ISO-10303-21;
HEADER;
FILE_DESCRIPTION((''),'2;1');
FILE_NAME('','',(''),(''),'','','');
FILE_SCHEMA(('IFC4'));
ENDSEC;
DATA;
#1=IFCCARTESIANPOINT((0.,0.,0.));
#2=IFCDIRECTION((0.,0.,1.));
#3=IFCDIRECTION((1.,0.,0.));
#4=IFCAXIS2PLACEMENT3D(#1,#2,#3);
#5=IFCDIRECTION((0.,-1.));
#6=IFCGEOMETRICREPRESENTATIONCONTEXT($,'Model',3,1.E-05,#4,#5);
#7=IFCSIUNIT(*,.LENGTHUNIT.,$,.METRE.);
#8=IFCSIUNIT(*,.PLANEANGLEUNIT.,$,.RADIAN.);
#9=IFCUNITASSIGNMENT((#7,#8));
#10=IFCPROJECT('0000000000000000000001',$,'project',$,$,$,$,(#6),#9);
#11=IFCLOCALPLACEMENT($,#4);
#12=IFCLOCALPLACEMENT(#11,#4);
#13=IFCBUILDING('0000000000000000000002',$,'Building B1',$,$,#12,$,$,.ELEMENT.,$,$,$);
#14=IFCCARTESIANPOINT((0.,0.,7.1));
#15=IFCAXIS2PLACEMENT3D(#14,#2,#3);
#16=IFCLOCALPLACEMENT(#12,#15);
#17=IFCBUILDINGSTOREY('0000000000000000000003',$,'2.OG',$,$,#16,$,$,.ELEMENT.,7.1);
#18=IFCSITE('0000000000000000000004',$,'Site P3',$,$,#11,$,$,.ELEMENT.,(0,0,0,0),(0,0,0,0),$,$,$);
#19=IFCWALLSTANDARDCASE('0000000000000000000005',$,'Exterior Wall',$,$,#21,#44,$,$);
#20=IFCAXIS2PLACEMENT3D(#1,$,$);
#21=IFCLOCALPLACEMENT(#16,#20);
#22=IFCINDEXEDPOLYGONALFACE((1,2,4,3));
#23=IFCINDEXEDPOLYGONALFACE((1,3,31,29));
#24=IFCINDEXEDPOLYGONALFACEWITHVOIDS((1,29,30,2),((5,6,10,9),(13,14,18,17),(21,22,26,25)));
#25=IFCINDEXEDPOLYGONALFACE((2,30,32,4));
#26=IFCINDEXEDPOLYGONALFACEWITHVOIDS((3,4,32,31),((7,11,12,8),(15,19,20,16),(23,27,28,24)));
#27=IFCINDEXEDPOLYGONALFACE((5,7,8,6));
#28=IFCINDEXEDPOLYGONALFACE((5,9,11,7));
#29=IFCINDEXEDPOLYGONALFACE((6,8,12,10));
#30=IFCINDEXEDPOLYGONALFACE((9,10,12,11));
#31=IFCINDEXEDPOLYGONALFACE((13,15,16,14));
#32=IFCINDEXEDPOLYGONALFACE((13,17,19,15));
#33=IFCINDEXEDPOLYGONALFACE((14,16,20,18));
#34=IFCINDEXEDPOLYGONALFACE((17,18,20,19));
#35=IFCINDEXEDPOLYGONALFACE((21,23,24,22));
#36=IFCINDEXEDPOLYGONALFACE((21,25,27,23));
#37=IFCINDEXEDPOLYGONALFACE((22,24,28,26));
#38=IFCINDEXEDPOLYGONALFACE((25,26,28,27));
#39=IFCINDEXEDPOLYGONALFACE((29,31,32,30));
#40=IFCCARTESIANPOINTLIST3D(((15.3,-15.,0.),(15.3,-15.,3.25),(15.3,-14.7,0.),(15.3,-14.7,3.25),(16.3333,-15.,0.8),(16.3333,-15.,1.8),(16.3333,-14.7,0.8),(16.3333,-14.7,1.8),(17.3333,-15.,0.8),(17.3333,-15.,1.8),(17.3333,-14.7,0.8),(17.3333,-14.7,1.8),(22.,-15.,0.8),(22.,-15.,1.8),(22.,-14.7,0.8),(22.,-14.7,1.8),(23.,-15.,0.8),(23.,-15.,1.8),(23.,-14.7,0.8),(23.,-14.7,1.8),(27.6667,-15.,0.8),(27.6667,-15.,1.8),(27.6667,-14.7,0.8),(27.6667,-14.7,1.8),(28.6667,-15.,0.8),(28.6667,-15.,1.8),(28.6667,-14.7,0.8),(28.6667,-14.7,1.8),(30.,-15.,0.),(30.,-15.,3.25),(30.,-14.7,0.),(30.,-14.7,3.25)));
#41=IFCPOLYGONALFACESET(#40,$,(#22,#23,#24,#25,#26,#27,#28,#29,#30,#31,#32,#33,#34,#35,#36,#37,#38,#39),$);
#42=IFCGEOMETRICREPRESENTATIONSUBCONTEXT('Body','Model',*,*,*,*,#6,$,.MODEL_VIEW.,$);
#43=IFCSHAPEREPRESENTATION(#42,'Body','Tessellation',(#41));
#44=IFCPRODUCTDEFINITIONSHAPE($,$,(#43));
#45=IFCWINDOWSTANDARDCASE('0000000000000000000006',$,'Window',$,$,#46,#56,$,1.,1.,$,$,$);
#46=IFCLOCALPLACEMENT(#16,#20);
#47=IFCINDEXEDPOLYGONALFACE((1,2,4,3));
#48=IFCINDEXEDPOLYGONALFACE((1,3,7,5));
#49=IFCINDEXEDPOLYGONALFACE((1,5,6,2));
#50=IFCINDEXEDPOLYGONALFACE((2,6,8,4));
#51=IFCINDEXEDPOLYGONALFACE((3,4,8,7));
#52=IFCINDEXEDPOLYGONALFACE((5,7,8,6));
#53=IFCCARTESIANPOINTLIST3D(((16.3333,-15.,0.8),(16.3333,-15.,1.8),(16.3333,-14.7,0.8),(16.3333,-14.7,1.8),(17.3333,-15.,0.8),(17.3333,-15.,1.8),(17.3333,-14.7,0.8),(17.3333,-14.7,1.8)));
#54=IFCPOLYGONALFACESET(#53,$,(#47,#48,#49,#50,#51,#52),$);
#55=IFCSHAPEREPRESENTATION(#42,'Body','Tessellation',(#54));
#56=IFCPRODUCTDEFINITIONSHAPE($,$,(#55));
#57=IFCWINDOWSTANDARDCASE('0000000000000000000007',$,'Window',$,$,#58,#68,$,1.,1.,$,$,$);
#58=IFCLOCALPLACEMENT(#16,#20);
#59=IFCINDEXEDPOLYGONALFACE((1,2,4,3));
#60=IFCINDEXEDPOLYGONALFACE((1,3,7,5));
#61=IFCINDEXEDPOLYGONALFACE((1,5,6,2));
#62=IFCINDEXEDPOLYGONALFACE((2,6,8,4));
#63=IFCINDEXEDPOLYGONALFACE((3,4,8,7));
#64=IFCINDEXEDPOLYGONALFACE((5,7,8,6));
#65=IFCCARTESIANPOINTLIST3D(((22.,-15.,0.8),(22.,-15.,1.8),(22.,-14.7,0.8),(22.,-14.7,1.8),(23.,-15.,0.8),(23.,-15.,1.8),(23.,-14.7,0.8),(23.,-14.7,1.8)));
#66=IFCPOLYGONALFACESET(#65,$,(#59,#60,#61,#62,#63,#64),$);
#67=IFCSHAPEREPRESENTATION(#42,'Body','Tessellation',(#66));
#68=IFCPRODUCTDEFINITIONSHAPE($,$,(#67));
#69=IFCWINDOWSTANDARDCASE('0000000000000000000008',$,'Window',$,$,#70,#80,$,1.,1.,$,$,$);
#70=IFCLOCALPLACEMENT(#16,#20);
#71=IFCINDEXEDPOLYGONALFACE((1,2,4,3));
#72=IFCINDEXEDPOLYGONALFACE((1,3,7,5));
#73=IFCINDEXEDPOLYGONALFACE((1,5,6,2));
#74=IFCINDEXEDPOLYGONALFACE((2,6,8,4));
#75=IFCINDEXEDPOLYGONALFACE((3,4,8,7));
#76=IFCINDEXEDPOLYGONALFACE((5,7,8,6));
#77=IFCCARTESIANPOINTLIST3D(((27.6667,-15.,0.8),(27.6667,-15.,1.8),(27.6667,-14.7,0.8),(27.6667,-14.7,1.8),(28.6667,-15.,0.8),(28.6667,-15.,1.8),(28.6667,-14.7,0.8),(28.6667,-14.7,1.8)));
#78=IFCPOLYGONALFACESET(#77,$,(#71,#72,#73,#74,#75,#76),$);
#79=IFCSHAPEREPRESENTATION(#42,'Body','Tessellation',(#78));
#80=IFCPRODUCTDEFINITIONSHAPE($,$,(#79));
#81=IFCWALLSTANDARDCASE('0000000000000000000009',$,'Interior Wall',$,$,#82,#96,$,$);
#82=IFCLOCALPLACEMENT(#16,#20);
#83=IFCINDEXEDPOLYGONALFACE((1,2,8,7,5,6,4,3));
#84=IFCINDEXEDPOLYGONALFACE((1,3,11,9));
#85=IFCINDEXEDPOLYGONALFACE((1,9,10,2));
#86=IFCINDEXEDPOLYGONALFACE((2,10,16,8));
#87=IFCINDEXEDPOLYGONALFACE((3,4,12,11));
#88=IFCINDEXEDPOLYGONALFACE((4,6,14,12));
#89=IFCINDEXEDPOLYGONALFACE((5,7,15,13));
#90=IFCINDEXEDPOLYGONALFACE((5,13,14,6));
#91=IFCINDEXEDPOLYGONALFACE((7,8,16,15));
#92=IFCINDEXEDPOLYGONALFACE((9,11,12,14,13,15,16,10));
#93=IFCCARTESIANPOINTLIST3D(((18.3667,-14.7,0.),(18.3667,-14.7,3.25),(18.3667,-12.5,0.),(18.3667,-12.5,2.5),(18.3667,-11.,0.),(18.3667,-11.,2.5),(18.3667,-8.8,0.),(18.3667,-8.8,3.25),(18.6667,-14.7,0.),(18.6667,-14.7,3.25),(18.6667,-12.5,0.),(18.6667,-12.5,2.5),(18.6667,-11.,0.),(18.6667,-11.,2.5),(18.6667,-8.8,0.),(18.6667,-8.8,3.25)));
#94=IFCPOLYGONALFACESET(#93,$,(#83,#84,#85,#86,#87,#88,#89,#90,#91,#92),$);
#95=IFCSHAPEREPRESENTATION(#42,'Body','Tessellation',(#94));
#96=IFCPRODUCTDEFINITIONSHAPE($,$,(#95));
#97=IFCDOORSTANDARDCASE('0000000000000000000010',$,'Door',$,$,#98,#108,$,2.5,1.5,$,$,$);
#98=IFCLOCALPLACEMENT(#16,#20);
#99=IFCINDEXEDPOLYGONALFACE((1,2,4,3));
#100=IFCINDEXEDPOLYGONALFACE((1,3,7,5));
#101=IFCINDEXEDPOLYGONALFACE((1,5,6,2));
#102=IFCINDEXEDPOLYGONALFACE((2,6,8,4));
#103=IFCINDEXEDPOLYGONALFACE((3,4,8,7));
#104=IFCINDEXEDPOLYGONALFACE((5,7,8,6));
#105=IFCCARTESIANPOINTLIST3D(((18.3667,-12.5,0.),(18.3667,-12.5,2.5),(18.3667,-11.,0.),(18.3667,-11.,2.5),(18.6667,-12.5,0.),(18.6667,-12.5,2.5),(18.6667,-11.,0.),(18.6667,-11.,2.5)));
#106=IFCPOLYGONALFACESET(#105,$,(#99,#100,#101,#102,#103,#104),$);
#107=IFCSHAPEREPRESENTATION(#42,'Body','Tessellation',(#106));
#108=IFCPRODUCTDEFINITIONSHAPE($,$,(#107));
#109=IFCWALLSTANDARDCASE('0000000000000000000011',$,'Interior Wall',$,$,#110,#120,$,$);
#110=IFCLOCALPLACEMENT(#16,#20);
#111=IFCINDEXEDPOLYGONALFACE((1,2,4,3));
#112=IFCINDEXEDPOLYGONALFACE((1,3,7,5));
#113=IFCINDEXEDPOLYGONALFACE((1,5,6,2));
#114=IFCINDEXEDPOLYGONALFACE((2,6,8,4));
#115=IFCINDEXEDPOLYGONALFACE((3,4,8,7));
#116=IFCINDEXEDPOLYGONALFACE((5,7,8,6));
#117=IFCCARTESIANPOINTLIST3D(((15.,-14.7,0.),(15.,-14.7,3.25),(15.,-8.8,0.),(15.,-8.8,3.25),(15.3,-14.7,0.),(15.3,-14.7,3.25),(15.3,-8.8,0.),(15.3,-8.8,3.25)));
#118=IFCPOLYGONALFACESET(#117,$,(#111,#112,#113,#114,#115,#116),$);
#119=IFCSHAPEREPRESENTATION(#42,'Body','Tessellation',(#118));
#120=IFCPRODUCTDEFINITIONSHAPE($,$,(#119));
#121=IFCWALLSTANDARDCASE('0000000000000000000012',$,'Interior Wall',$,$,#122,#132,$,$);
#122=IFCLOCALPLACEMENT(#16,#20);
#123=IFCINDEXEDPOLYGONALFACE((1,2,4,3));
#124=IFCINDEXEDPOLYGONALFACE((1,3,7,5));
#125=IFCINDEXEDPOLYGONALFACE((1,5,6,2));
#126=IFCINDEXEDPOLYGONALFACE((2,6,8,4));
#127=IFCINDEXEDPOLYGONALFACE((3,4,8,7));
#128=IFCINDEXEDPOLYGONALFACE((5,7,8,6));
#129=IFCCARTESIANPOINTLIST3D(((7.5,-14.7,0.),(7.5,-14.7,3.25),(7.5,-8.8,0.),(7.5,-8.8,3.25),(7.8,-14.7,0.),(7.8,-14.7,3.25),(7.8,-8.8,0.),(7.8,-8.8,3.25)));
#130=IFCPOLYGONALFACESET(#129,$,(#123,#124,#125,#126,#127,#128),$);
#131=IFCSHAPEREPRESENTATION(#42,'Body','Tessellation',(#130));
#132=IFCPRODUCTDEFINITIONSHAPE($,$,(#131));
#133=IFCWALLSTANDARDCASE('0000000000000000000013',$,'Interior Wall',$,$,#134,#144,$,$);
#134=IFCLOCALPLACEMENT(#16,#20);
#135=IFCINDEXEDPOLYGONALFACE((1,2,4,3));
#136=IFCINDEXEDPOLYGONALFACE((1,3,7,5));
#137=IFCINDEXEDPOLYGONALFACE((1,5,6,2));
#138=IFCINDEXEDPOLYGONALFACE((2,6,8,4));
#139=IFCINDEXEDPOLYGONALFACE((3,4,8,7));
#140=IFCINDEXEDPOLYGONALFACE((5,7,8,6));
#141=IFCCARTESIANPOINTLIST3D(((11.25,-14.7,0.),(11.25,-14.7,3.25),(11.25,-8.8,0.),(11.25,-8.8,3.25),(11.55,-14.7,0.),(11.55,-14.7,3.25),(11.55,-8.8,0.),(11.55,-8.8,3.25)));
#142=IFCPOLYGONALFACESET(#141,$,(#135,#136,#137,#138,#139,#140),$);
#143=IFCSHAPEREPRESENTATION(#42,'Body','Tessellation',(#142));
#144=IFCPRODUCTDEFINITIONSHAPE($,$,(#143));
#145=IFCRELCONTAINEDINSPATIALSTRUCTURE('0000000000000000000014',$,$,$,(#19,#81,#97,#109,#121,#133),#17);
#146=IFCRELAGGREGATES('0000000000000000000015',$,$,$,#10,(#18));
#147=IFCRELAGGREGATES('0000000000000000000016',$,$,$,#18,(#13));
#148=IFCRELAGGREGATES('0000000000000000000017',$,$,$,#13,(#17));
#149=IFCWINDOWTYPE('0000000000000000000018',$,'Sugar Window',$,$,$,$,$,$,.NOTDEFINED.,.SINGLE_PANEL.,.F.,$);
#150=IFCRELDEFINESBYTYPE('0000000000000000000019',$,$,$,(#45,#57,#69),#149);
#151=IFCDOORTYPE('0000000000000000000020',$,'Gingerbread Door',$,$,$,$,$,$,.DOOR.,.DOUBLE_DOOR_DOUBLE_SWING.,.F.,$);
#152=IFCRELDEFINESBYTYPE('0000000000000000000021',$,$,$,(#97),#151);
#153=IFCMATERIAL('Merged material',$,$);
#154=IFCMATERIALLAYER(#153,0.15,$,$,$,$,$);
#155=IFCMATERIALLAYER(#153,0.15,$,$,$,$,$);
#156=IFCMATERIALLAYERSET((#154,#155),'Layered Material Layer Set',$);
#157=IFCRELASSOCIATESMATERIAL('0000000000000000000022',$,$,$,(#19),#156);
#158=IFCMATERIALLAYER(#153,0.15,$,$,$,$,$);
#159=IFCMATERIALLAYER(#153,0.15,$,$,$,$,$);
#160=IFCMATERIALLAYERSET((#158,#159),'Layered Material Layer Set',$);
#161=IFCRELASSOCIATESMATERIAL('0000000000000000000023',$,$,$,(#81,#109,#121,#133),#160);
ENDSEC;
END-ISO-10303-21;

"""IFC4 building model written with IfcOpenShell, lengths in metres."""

from ifc_helpers import new_model, si_unit, direction, frame, origin_with_axes, place, context, subcontext, project, spatial, polyline, outline, extrude, source, transform, mapped, material, layer, layer_set, layer_usage, type_object, element, fill, save


model = new_model("IFC4")

# Units and contexts
model_context = context("Model", 3, precision=1e-05, world=origin_with_axes(), true_north=direction((0.0, -1.0)))
body_context = subcontext(model_context, "Body", "Model", "MODEL_VIEW")
ifc_project = project(units=[si_unit("LENGTHUNIT", "METRE"), si_unit("PLANEANGLEUNIT", "RADIAN")], contexts=[model_context])

# Site, building, storey
site_placement = place(None, origin_with_axes())
site = spatial("IfcSite", under=ifc_project, at=site_placement, Name="Site P3", CompositionType="ELEMENT", RefLatitude=(0, 0, 0, 0), RefLongitude=(0, 0, 0, 0))
building_placement = place(site_placement, origin_with_axes())
building = spatial("IfcBuilding", under=site, at=building_placement, Name="Building B1", CompositionType="ELEMENT")
storey_placement = place(building_placement, frame((0.0, 0.0, 7.1), z_axis=(0.0, 0.0, 1.0), x_axis=(1.0, 0.0, 0.0)))
storey = spatial("IfcBuildingStorey", under=building, at=storey_placement, Name="2.OG", CompositionType="ELEMENT", Elevation=7.1)

# Wall, openings, windows
ifc_material = material(Name="Merged material")
ifc_layer_1 = layer(ifc_material, 0.15)
ifc_layer_2 = layer(ifc_material, 0.15)
ifc_layer_set_1 = layer_set([ifc_layer_1, ifc_layer_2], Name="Layered Material Layer Set")
ifc_layer_usage_1 = layer_usage(ifc_layer_set_1, "AXIS2", "POSITIVE", -0.15)
wall_1_placement = place(storey_placement, frame((15.3, -14.85, 0.0), z_axis=(0.0, 0.0, 1.0), x_axis=(1.0, 0.0, 0.0)))
wall_1 = element("IfcWallStandardCase", 1, at=wall_1_placement, inside=storey, material=ifc_layer_usage_1, Name="Exterior Wall", context=body_context, shape_type="SweptSolid", body=[
    extrude(outline(polyline([(0.0, 0.15), (14.7, 0.15), (14.7, -0.15), (0.0, -0.15), (0.0, 0.15)])), origin_with_axes(), (0.0, 0.0, 1.0), 3.25),
])
opening_1_placement = place(wall_1_placement, frame((1.0333, 0.0, 0.8), z_axis=(0.0, 0.0, 1.0), x_axis=(1.0, 0.0, 0.0)))
opening_1 = element("IfcOpeningStandardCase", 2, at=opening_1_placement, cuts=wall_1, context=body_context, shape_type="SweptSolid", body=[
    extrude(outline(polyline([(0.0, 0.0), (0.0, 1.0), (1.0, 1.0), (1.0, 0.0), (0.0, 0.0)])), frame((0.0, -0.15, 0.0), z_axis=(0.0, 1.0, 0.0), x_axis=(0.0, 0.0, 1.0)), (0.0, 0.0, 1.0), 0.3),
])
opening_2_placement = place(wall_1_placement, frame((6.7, 0.0, 0.8), z_axis=(0.0, 0.0, 1.0), x_axis=(1.0, 0.0, 0.0)))
opening_2 = element("IfcOpeningStandardCase", 3, at=opening_2_placement, cuts=wall_1, context=body_context, shape_type="SweptSolid", body=[
    extrude(outline(polyline([(0.0, 0.0), (0.0, 1.0), (1.0, 1.0), (1.0, 0.0), (0.0, 0.0)])), frame((0.0, -0.15, 0.0), z_axis=(0.0, 1.0, 0.0), x_axis=(0.0, 0.0, 1.0)), (0.0, 0.0, 1.0), 0.3),
])
opening_3_placement = place(wall_1_placement, frame((12.3667, 0.0, 0.8), z_axis=(0.0, 0.0, 1.0), x_axis=(1.0, 0.0, 0.0)))
opening_3 = element("IfcOpeningStandardCase", 4, at=opening_3_placement, cuts=wall_1, context=body_context, shape_type="SweptSolid", body=[
    extrude(outline(polyline([(0.0, 0.0), (0.0, 1.0), (1.0, 1.0), (1.0, 0.0), (0.0, 0.0)])), frame((0.0, -0.15, 0.0), z_axis=(0.0, 1.0, 0.0), x_axis=(0.0, 0.0, 1.0)), (0.0, 0.0, 1.0), 0.3),
])
window_type = type_object("IfcWindowType", Name="Sugar Window", ParameterTakesPrecedence=False, PartitioningType="SINGLE_PANEL", PredefinedType="NOTDEFINED")
shared_shape_1 = source(origin_with_axes(), body_context, "Body", "SweptSolid", [
    extrude(outline(polyline([(0.0, 0.0), (0.0, 1.0), (1.0, 1.0), (1.0, 0.0), (0.0, 0.0)])), frame((0.0, -0.15, 0.0), z_axis=(0.0, 1.0, 0.0), x_axis=(0.0, 0.0, 1.0)), (0.0, 0.0, 1.0), 0.3),
])
window_1_placement = place(opening_1_placement, origin_with_axes())
window_1 = element("IfcWindowStandardCase", 5, at=window_1_placement, type_object=window_type, Name="Window", OverallHeight=1.0, OverallWidth=1.0, context=body_context, shape_type="MappedRepresentation", body=[
    mapped(shared_shape_1, transform((0.0, 0.0, 0.0))),
])
fill(opening_1, window_1)
window_2_placement = place(opening_2_placement, origin_with_axes())
window_2 = element("IfcWindowStandardCase", 6, at=window_2_placement, type_object=window_type, Name="Window", OverallHeight=1.0, OverallWidth=1.0, context=body_context, shape_type="MappedRepresentation", body=[
    mapped(shared_shape_1, transform((0.0, 0.0, 0.0))),
])
fill(opening_2, window_2)
window_3_placement = place(opening_3_placement, origin_with_axes())
window_3 = element("IfcWindowStandardCase", 7, at=window_3_placement, type_object=window_type, Name="Window", OverallHeight=1.0, OverallWidth=1.0, context=body_context, shape_type="MappedRepresentation", body=[
    mapped(shared_shape_1, transform((0.0, 0.0, 0.0))),
])
fill(opening_3, window_3)

# Wall, opening, door
ifc_layer_3 = layer(ifc_material, 0.15)
ifc_layer_4 = layer(ifc_material, 0.15)
ifc_layer_set_2 = layer_set([ifc_layer_3, ifc_layer_4], Name="Layered Material Layer Set")
ifc_layer_usage_2 = layer_usage(ifc_layer_set_2, "AXIS2", "POSITIVE", -0.15)
wall_2_placement = place(storey_placement, frame((18.5167, -8.8, 0.0), z_axis=(0.0, 0.0, 1.0), x_axis=(0.0, -1.0, 0.0)))
wall_2 = element("IfcWallStandardCase", 8, at=wall_2_placement, inside=storey, material=ifc_layer_usage_2, Name="Interior Wall", context=body_context, shape_type="SweptSolid", body=[
    extrude(outline(polyline([(0.0, 0.15), (5.9, 0.15), (5.9, -0.15), (0.0, -0.15), (0.0, 0.15)])), origin_with_axes(), (0.0, 0.0, 1.0), 3.25),
])
opening_4_placement = place(wall_2_placement, frame((2.2, 0.0, 0.0), z_axis=(0.0, 0.0, 1.0), x_axis=(1.0, 0.0, 0.0)))
opening_4 = element("IfcOpeningStandardCase", 9, at=opening_4_placement, cuts=wall_2, context=body_context, shape_type="SweptSolid", body=[
    extrude(outline(polyline([(0.0, 0.0), (0.0, 1.5), (2.5, 1.5), (2.5, 0.0), (0.0, 0.0)])), frame((0.0, -0.15, 0.0), z_axis=(0.0, 1.0, 0.0), x_axis=(0.0, 0.0, 1.0)), (0.0, 0.0, 1.0), 0.3),
])
door_type = type_object("IfcDoorType", Name="Gingerbread Door", OperationType="DOUBLE_DOOR_DOUBLE_SWING", ParameterTakesPrecedence=False, PredefinedType="DOOR")
shared_shape_2 = source(origin_with_axes(), body_context, "Body", "SweptSolid", [
    extrude(outline(polyline([(0.0, 0.0), (0.0, 1.5), (2.5, 1.5), (2.5, 0.0), (0.0, 0.0)])), frame((0.0, -0.15, 0.0), z_axis=(0.0, 1.0, 0.0), x_axis=(0.0, 0.0, 1.0)), (0.0, 0.0, 1.0), 0.3),
])
door_placement = place(opening_4_placement, origin_with_axes())
door = element("IfcDoorStandardCase", 10, at=door_placement, inside=storey, type_object=door_type, Name="Door", OverallHeight=2.5, OverallWidth=1.5, context=body_context, shape_type="MappedRepresentation", body=[
    mapped(shared_shape_2, transform((0.0, 0.0, 0.0))),
])
fill(opening_4, door)

# Walls
for number, where, z_axis, x_axis, name in (
    (11, (15.15, -8.8, 0.0), (0.0, 0.0, 1.0), (0.0, -1.0, 0.0), "Interior Wall"),
    (12, (7.65, -8.8, 0.0), (0.0, 0.0, 1.0), (0.0, -1.0, 0.0), "Interior Wall"),
    (13, (11.4, -8.8, 0.0), (0.0, 0.0, 1.0), (0.0, -1.0, 0.0), "Interior Wall"),
):
    element("IfcWallStandardCase", number, at=place(storey_placement, frame(where, z_axis=z_axis, x_axis=x_axis)), inside=storey, material=ifc_layer_usage_2, Name=name, context=body_context, shape_type="SweptSolid", body=[
        extrude(outline(polyline([(0.0, 0.15), (5.9, 0.15), (5.9, -0.15), (0.0, -0.15), (0.0, 0.15)])), origin_with_axes(), (0.0, 0.0, 1.0), 3.25),
    ])

save(model, "model.ifc")
